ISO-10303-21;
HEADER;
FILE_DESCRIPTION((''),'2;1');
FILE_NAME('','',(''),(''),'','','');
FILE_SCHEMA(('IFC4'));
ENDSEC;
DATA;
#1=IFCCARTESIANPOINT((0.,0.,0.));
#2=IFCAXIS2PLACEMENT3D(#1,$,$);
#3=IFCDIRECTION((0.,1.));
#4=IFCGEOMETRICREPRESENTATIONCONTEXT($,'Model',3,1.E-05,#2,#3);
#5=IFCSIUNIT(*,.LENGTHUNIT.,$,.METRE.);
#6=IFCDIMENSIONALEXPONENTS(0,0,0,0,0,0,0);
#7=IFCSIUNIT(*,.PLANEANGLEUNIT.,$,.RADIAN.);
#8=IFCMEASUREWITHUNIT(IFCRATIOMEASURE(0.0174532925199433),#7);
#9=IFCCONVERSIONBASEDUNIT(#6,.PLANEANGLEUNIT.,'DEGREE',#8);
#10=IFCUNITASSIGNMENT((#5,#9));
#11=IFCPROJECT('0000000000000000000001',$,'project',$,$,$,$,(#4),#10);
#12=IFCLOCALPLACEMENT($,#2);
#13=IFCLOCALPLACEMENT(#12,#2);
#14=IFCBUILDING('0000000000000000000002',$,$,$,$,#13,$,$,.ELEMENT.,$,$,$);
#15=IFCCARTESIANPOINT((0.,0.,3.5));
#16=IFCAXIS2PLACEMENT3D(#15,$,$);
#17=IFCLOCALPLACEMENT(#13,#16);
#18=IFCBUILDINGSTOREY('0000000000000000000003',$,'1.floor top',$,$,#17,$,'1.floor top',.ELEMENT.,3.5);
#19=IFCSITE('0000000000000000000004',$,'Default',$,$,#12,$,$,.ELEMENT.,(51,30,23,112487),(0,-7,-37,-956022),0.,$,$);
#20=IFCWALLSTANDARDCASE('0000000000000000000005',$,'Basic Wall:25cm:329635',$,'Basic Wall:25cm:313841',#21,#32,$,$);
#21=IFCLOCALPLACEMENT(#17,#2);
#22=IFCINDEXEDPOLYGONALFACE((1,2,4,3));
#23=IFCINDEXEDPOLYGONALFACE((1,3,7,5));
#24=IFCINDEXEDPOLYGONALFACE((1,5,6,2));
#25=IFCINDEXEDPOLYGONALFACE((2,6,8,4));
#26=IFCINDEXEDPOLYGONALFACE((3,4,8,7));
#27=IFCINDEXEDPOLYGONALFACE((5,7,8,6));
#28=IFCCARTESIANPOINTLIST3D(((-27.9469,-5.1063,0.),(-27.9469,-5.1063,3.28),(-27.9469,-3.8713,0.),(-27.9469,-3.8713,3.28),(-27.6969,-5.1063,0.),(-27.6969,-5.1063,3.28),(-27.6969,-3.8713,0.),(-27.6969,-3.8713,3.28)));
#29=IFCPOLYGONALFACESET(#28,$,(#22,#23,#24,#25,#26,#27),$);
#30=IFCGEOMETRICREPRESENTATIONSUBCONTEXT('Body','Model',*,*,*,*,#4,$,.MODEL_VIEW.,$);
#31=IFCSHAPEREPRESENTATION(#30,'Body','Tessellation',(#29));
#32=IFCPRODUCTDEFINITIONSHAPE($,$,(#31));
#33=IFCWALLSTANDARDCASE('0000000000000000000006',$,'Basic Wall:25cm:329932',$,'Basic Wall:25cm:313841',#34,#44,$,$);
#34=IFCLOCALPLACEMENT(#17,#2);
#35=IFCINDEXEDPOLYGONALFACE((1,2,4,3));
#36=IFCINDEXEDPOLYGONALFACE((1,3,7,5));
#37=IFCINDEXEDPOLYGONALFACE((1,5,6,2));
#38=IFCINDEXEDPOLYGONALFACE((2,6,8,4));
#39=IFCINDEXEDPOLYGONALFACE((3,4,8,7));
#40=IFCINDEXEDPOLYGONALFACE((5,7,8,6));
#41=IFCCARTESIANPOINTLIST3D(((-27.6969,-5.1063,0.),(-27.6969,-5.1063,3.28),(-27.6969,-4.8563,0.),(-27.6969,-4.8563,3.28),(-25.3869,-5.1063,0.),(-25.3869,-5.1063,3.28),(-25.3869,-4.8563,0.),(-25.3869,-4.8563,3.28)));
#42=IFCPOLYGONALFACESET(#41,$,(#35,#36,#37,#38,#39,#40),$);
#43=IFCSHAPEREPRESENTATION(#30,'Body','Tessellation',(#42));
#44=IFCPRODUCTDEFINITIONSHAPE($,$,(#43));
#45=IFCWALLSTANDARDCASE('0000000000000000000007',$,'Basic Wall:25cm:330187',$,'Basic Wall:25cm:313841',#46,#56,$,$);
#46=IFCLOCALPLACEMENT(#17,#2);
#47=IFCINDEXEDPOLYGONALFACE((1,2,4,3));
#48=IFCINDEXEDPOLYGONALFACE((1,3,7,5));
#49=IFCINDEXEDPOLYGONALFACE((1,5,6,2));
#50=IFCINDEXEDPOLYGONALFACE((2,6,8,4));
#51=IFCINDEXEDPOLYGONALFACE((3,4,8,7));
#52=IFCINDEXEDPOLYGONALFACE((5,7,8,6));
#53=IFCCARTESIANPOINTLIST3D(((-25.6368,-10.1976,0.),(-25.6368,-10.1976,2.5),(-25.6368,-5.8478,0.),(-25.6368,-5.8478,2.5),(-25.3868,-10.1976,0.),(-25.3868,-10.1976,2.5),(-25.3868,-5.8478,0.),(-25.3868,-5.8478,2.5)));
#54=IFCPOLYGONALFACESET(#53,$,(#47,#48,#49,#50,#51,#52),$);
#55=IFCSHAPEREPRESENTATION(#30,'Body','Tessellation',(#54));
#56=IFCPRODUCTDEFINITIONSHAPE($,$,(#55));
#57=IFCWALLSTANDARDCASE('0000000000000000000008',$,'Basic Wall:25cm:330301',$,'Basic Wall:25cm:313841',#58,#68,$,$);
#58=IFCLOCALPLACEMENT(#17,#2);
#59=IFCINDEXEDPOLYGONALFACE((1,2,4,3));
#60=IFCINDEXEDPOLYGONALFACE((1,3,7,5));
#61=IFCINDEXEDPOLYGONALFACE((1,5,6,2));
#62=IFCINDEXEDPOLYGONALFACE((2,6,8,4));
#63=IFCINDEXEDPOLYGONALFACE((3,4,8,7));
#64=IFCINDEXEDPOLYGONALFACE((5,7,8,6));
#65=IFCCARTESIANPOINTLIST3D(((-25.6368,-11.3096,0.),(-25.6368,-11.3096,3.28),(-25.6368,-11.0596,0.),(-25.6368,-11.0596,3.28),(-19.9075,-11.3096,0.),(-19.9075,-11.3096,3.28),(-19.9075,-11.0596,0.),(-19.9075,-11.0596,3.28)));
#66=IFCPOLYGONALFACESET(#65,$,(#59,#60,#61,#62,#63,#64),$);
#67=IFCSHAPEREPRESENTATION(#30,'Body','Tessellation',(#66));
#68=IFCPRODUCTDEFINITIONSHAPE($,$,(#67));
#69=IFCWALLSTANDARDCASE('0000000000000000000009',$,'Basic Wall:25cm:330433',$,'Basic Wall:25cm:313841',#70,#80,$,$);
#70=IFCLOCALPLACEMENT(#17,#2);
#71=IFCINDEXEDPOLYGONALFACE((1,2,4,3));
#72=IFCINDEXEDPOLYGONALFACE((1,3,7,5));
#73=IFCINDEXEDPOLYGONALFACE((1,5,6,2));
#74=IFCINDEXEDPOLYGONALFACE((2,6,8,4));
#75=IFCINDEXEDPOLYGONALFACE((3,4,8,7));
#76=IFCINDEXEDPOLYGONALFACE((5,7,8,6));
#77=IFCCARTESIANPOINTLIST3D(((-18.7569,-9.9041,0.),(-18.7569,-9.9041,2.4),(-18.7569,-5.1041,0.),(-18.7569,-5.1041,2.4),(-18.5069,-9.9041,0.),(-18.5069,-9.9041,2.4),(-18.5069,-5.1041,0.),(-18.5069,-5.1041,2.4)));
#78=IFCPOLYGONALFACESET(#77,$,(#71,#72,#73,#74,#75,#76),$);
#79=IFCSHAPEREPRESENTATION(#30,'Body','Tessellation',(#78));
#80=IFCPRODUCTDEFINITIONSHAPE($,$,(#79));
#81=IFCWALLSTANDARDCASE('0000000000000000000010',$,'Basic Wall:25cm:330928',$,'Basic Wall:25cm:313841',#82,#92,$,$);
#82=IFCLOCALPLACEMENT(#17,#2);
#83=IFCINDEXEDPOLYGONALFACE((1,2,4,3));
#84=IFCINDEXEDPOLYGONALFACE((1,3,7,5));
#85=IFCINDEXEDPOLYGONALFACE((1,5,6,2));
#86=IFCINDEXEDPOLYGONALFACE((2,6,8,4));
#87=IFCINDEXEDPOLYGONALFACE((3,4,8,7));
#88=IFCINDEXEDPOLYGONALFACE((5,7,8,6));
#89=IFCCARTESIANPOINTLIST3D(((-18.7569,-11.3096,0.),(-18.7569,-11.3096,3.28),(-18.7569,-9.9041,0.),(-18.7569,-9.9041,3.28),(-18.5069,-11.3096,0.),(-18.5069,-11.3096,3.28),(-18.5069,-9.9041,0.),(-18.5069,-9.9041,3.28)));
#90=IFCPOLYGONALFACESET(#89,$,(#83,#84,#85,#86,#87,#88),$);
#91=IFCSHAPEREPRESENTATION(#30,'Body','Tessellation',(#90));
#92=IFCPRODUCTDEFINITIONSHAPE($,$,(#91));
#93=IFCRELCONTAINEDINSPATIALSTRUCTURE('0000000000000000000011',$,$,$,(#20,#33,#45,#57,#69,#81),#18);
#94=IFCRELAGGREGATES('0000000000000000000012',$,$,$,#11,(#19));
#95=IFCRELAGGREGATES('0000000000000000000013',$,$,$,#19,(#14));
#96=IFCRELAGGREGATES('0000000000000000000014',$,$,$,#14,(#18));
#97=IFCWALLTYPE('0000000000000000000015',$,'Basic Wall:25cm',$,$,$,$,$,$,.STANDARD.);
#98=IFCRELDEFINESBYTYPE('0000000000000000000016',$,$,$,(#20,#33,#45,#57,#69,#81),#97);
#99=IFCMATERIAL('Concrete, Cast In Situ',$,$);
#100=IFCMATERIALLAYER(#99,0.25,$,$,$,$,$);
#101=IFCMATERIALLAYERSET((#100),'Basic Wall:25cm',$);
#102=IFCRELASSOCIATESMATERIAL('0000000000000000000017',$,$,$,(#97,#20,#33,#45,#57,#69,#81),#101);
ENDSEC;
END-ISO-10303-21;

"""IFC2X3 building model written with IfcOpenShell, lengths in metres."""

from ifc_helpers import new_model, entity, si_unit, converted_unit, direction, frame, frame_2d, origin, place, context, subcontext, project, spatial, rectangle, extrude, material, layer, layer_set, layer_usage, type_object, element, save


model = new_model("IFC2X3")

# Units and contexts
model_context = context("Model", 3, precision=1e-05, world=origin(), true_north=direction((0.0, 1.0)))
body_context = subcontext(model_context, "Body", "Model", "MODEL_VIEW")
ifc_project = project(units=[si_unit("LENGTHUNIT", "METRE"), converted_unit("PLANEANGLEUNIT", "DEGREE", entity("IfcRatioMeasure", 0.0174532925199433), si_unit("PLANEANGLEUNIT", "RADIAN"), dimensions=[0, 0, 0, 0, 0, 0, 0])], contexts=[model_context])

# Site, building, storey
site_placement = place(None, origin())
site = spatial("IfcSite", under=ifc_project, at=site_placement, Name="Default", CompositionType="ELEMENT", RefLatitude=(51, 30, 23, 112487), RefLongitude=(0, -7, -37, -956022), RefElevation=0.0)
building_placement = place(site_placement, origin())
building = spatial("IfcBuilding", under=site, at=building_placement, CompositionType="ELEMENT")
storey_placement = place(building_placement, frame((0.0, 0.0, 3.5)))
storey = spatial("IfcBuildingStorey", under=building, at=storey_placement, Name="1.floor top", LongName="1.floor top", CompositionType="ELEMENT", Elevation=3.5)

# Shared definitions
ifc_material_1 = material(Name="Concrete, Cast In Situ")

# Shared definitions
ifc_layer = layer(ifc_material_1, 0.25)
ifc_layer_set = layer_set([ifc_layer], Name="Basic Wall:25cm")
wall_type = type_object("IfcWallType", Name="Basic Wall:25cm", PredefinedType="STANDARD", material=ifc_layer_set)

# Walls
ifc_layer_usage_1 = layer_usage(ifc_layer_set, "AXIS2", "NEGATIVE", 0.125)
wall_1_placement = place(storey_placement, frame((-27.8219, -3.8713, 0.0), z_axis=(0.0, 0.0, 1.0), x_axis=(0.0, -1.0, 0.0)))
element("IfcWallStandardCase", 1, at=wall_1_placement, inside=storey, type_object=wall_type, material=ifc_layer_usage_1, Name="Basic Wall:25cm:329635", ObjectType="Basic Wall:25cm:313841", context=body_context, shape_type="SweptSolid", body=[
    extrude(rectangle(XDim=1.235, YDim=0.25, at=frame_2d((0.6175, 0.0), x_axis=(-1.0, 0.0))), origin(), (0.0, 0.0, 1.0), 3.28),
])
ifc_layer_usage_2 = layer_usage(ifc_layer_set, "AXIS2", "NEGATIVE", 0.125)
wall_2_placement = place(storey_placement, frame((-27.6969, -4.9813, 0.0)))
element("IfcWallStandardCase", 2, at=wall_2_placement, inside=storey, type_object=wall_type, material=ifc_layer_usage_2, Name="Basic Wall:25cm:329932", ObjectType="Basic Wall:25cm:313841", context=body_context, shape_type="SweptSolid", body=[
    extrude(rectangle(XDim=2.31, YDim=0.25, at=frame_2d((1.155, 0.0), x_axis=(-1.0, 0.0))), origin(), (0.0, 0.0, 1.0), 3.28),
])
ifc_layer_usage_3 = layer_usage(ifc_layer_set, "AXIS2", "NEGATIVE", 0.125)
wall_3_placement = place(storey_placement, frame((-25.5118, -5.8478, 0.0), z_axis=(0.0, 0.0, 1.0), x_axis=(0.0, -1.0, 0.0)))
element("IfcWallStandardCase", 3, at=wall_3_placement, inside=storey, type_object=wall_type, material=ifc_layer_usage_3, Name="Basic Wall:25cm:330187", ObjectType="Basic Wall:25cm:313841", context=body_context, shape_type="SweptSolid", body=[
    extrude(rectangle(XDim=4.3498, YDim=0.25, at=frame_2d((2.1749, 0.0), x_axis=(-1.0, 0.0))), origin(), (0.0, 0.0, 1.0), 2.5),
])
ifc_layer_usage_4 = layer_usage(ifc_layer_set, "AXIS2", "NEGATIVE", 0.125)
wall_4_placement = place(storey_placement, frame((-25.6368, -11.1846, 0.0)))
element("IfcWallStandardCase", 4, at=wall_4_placement, inside=storey, type_object=wall_type, material=ifc_layer_usage_4, Name="Basic Wall:25cm:330301", ObjectType="Basic Wall:25cm:313841", context=body_context, shape_type="SweptSolid", body=[
    extrude(rectangle(XDim=5.7293, YDim=0.25, at=frame_2d((2.8646, 0.0), x_axis=(-1.0, 0.0))), origin(), (0.0, 0.0, 1.0), 3.28),
])
ifc_layer_usage_5 = layer_usage(ifc_layer_set, "AXIS2", "NEGATIVE", 0.125)
wall_5_placement = place(storey_placement, frame((-18.6319, -9.9041, 0.0), z_axis=(0.0, 0.0, 1.0), x_axis=(0.0, 1.0, 0.0)))
element("IfcWallStandardCase", 5, at=wall_5_placement, inside=storey, type_object=wall_type, material=ifc_layer_usage_5, Name="Basic Wall:25cm:330433", ObjectType="Basic Wall:25cm:313841", context=body_context, shape_type="SweptSolid", body=[
    extrude(rectangle(XDim=4.8, YDim=0.25, at=frame_2d((2.4, 0.0), x_axis=(-1.0, 0.0))), origin(), (0.0, 0.0, 1.0), 2.4),
])
ifc_layer_usage_6 = layer_usage(ifc_layer_set, "AXIS2", "POSITIVE", -0.125)
wall_6_placement = place(storey_placement, frame((-18.6319, -9.9041, 0.0), z_axis=(0.0, 0.0, 1.0), x_axis=(0.0, -1.0, 0.0)))
element("IfcWallStandardCase", 6, at=wall_6_placement, inside=storey, type_object=wall_type, material=ifc_layer_usage_6, Name="Basic Wall:25cm:330928", ObjectType="Basic Wall:25cm:313841", context=body_context, shape_type="SweptSolid", body=[
    extrude(rectangle(XDim=1.4055, YDim=0.25, at=frame_2d((0.7028, 0.0), x_axis=(-1.0, 0.0))), origin(), (0.0, 0.0, 1.0), 3.28),
])

save(model, "model.ifc")
